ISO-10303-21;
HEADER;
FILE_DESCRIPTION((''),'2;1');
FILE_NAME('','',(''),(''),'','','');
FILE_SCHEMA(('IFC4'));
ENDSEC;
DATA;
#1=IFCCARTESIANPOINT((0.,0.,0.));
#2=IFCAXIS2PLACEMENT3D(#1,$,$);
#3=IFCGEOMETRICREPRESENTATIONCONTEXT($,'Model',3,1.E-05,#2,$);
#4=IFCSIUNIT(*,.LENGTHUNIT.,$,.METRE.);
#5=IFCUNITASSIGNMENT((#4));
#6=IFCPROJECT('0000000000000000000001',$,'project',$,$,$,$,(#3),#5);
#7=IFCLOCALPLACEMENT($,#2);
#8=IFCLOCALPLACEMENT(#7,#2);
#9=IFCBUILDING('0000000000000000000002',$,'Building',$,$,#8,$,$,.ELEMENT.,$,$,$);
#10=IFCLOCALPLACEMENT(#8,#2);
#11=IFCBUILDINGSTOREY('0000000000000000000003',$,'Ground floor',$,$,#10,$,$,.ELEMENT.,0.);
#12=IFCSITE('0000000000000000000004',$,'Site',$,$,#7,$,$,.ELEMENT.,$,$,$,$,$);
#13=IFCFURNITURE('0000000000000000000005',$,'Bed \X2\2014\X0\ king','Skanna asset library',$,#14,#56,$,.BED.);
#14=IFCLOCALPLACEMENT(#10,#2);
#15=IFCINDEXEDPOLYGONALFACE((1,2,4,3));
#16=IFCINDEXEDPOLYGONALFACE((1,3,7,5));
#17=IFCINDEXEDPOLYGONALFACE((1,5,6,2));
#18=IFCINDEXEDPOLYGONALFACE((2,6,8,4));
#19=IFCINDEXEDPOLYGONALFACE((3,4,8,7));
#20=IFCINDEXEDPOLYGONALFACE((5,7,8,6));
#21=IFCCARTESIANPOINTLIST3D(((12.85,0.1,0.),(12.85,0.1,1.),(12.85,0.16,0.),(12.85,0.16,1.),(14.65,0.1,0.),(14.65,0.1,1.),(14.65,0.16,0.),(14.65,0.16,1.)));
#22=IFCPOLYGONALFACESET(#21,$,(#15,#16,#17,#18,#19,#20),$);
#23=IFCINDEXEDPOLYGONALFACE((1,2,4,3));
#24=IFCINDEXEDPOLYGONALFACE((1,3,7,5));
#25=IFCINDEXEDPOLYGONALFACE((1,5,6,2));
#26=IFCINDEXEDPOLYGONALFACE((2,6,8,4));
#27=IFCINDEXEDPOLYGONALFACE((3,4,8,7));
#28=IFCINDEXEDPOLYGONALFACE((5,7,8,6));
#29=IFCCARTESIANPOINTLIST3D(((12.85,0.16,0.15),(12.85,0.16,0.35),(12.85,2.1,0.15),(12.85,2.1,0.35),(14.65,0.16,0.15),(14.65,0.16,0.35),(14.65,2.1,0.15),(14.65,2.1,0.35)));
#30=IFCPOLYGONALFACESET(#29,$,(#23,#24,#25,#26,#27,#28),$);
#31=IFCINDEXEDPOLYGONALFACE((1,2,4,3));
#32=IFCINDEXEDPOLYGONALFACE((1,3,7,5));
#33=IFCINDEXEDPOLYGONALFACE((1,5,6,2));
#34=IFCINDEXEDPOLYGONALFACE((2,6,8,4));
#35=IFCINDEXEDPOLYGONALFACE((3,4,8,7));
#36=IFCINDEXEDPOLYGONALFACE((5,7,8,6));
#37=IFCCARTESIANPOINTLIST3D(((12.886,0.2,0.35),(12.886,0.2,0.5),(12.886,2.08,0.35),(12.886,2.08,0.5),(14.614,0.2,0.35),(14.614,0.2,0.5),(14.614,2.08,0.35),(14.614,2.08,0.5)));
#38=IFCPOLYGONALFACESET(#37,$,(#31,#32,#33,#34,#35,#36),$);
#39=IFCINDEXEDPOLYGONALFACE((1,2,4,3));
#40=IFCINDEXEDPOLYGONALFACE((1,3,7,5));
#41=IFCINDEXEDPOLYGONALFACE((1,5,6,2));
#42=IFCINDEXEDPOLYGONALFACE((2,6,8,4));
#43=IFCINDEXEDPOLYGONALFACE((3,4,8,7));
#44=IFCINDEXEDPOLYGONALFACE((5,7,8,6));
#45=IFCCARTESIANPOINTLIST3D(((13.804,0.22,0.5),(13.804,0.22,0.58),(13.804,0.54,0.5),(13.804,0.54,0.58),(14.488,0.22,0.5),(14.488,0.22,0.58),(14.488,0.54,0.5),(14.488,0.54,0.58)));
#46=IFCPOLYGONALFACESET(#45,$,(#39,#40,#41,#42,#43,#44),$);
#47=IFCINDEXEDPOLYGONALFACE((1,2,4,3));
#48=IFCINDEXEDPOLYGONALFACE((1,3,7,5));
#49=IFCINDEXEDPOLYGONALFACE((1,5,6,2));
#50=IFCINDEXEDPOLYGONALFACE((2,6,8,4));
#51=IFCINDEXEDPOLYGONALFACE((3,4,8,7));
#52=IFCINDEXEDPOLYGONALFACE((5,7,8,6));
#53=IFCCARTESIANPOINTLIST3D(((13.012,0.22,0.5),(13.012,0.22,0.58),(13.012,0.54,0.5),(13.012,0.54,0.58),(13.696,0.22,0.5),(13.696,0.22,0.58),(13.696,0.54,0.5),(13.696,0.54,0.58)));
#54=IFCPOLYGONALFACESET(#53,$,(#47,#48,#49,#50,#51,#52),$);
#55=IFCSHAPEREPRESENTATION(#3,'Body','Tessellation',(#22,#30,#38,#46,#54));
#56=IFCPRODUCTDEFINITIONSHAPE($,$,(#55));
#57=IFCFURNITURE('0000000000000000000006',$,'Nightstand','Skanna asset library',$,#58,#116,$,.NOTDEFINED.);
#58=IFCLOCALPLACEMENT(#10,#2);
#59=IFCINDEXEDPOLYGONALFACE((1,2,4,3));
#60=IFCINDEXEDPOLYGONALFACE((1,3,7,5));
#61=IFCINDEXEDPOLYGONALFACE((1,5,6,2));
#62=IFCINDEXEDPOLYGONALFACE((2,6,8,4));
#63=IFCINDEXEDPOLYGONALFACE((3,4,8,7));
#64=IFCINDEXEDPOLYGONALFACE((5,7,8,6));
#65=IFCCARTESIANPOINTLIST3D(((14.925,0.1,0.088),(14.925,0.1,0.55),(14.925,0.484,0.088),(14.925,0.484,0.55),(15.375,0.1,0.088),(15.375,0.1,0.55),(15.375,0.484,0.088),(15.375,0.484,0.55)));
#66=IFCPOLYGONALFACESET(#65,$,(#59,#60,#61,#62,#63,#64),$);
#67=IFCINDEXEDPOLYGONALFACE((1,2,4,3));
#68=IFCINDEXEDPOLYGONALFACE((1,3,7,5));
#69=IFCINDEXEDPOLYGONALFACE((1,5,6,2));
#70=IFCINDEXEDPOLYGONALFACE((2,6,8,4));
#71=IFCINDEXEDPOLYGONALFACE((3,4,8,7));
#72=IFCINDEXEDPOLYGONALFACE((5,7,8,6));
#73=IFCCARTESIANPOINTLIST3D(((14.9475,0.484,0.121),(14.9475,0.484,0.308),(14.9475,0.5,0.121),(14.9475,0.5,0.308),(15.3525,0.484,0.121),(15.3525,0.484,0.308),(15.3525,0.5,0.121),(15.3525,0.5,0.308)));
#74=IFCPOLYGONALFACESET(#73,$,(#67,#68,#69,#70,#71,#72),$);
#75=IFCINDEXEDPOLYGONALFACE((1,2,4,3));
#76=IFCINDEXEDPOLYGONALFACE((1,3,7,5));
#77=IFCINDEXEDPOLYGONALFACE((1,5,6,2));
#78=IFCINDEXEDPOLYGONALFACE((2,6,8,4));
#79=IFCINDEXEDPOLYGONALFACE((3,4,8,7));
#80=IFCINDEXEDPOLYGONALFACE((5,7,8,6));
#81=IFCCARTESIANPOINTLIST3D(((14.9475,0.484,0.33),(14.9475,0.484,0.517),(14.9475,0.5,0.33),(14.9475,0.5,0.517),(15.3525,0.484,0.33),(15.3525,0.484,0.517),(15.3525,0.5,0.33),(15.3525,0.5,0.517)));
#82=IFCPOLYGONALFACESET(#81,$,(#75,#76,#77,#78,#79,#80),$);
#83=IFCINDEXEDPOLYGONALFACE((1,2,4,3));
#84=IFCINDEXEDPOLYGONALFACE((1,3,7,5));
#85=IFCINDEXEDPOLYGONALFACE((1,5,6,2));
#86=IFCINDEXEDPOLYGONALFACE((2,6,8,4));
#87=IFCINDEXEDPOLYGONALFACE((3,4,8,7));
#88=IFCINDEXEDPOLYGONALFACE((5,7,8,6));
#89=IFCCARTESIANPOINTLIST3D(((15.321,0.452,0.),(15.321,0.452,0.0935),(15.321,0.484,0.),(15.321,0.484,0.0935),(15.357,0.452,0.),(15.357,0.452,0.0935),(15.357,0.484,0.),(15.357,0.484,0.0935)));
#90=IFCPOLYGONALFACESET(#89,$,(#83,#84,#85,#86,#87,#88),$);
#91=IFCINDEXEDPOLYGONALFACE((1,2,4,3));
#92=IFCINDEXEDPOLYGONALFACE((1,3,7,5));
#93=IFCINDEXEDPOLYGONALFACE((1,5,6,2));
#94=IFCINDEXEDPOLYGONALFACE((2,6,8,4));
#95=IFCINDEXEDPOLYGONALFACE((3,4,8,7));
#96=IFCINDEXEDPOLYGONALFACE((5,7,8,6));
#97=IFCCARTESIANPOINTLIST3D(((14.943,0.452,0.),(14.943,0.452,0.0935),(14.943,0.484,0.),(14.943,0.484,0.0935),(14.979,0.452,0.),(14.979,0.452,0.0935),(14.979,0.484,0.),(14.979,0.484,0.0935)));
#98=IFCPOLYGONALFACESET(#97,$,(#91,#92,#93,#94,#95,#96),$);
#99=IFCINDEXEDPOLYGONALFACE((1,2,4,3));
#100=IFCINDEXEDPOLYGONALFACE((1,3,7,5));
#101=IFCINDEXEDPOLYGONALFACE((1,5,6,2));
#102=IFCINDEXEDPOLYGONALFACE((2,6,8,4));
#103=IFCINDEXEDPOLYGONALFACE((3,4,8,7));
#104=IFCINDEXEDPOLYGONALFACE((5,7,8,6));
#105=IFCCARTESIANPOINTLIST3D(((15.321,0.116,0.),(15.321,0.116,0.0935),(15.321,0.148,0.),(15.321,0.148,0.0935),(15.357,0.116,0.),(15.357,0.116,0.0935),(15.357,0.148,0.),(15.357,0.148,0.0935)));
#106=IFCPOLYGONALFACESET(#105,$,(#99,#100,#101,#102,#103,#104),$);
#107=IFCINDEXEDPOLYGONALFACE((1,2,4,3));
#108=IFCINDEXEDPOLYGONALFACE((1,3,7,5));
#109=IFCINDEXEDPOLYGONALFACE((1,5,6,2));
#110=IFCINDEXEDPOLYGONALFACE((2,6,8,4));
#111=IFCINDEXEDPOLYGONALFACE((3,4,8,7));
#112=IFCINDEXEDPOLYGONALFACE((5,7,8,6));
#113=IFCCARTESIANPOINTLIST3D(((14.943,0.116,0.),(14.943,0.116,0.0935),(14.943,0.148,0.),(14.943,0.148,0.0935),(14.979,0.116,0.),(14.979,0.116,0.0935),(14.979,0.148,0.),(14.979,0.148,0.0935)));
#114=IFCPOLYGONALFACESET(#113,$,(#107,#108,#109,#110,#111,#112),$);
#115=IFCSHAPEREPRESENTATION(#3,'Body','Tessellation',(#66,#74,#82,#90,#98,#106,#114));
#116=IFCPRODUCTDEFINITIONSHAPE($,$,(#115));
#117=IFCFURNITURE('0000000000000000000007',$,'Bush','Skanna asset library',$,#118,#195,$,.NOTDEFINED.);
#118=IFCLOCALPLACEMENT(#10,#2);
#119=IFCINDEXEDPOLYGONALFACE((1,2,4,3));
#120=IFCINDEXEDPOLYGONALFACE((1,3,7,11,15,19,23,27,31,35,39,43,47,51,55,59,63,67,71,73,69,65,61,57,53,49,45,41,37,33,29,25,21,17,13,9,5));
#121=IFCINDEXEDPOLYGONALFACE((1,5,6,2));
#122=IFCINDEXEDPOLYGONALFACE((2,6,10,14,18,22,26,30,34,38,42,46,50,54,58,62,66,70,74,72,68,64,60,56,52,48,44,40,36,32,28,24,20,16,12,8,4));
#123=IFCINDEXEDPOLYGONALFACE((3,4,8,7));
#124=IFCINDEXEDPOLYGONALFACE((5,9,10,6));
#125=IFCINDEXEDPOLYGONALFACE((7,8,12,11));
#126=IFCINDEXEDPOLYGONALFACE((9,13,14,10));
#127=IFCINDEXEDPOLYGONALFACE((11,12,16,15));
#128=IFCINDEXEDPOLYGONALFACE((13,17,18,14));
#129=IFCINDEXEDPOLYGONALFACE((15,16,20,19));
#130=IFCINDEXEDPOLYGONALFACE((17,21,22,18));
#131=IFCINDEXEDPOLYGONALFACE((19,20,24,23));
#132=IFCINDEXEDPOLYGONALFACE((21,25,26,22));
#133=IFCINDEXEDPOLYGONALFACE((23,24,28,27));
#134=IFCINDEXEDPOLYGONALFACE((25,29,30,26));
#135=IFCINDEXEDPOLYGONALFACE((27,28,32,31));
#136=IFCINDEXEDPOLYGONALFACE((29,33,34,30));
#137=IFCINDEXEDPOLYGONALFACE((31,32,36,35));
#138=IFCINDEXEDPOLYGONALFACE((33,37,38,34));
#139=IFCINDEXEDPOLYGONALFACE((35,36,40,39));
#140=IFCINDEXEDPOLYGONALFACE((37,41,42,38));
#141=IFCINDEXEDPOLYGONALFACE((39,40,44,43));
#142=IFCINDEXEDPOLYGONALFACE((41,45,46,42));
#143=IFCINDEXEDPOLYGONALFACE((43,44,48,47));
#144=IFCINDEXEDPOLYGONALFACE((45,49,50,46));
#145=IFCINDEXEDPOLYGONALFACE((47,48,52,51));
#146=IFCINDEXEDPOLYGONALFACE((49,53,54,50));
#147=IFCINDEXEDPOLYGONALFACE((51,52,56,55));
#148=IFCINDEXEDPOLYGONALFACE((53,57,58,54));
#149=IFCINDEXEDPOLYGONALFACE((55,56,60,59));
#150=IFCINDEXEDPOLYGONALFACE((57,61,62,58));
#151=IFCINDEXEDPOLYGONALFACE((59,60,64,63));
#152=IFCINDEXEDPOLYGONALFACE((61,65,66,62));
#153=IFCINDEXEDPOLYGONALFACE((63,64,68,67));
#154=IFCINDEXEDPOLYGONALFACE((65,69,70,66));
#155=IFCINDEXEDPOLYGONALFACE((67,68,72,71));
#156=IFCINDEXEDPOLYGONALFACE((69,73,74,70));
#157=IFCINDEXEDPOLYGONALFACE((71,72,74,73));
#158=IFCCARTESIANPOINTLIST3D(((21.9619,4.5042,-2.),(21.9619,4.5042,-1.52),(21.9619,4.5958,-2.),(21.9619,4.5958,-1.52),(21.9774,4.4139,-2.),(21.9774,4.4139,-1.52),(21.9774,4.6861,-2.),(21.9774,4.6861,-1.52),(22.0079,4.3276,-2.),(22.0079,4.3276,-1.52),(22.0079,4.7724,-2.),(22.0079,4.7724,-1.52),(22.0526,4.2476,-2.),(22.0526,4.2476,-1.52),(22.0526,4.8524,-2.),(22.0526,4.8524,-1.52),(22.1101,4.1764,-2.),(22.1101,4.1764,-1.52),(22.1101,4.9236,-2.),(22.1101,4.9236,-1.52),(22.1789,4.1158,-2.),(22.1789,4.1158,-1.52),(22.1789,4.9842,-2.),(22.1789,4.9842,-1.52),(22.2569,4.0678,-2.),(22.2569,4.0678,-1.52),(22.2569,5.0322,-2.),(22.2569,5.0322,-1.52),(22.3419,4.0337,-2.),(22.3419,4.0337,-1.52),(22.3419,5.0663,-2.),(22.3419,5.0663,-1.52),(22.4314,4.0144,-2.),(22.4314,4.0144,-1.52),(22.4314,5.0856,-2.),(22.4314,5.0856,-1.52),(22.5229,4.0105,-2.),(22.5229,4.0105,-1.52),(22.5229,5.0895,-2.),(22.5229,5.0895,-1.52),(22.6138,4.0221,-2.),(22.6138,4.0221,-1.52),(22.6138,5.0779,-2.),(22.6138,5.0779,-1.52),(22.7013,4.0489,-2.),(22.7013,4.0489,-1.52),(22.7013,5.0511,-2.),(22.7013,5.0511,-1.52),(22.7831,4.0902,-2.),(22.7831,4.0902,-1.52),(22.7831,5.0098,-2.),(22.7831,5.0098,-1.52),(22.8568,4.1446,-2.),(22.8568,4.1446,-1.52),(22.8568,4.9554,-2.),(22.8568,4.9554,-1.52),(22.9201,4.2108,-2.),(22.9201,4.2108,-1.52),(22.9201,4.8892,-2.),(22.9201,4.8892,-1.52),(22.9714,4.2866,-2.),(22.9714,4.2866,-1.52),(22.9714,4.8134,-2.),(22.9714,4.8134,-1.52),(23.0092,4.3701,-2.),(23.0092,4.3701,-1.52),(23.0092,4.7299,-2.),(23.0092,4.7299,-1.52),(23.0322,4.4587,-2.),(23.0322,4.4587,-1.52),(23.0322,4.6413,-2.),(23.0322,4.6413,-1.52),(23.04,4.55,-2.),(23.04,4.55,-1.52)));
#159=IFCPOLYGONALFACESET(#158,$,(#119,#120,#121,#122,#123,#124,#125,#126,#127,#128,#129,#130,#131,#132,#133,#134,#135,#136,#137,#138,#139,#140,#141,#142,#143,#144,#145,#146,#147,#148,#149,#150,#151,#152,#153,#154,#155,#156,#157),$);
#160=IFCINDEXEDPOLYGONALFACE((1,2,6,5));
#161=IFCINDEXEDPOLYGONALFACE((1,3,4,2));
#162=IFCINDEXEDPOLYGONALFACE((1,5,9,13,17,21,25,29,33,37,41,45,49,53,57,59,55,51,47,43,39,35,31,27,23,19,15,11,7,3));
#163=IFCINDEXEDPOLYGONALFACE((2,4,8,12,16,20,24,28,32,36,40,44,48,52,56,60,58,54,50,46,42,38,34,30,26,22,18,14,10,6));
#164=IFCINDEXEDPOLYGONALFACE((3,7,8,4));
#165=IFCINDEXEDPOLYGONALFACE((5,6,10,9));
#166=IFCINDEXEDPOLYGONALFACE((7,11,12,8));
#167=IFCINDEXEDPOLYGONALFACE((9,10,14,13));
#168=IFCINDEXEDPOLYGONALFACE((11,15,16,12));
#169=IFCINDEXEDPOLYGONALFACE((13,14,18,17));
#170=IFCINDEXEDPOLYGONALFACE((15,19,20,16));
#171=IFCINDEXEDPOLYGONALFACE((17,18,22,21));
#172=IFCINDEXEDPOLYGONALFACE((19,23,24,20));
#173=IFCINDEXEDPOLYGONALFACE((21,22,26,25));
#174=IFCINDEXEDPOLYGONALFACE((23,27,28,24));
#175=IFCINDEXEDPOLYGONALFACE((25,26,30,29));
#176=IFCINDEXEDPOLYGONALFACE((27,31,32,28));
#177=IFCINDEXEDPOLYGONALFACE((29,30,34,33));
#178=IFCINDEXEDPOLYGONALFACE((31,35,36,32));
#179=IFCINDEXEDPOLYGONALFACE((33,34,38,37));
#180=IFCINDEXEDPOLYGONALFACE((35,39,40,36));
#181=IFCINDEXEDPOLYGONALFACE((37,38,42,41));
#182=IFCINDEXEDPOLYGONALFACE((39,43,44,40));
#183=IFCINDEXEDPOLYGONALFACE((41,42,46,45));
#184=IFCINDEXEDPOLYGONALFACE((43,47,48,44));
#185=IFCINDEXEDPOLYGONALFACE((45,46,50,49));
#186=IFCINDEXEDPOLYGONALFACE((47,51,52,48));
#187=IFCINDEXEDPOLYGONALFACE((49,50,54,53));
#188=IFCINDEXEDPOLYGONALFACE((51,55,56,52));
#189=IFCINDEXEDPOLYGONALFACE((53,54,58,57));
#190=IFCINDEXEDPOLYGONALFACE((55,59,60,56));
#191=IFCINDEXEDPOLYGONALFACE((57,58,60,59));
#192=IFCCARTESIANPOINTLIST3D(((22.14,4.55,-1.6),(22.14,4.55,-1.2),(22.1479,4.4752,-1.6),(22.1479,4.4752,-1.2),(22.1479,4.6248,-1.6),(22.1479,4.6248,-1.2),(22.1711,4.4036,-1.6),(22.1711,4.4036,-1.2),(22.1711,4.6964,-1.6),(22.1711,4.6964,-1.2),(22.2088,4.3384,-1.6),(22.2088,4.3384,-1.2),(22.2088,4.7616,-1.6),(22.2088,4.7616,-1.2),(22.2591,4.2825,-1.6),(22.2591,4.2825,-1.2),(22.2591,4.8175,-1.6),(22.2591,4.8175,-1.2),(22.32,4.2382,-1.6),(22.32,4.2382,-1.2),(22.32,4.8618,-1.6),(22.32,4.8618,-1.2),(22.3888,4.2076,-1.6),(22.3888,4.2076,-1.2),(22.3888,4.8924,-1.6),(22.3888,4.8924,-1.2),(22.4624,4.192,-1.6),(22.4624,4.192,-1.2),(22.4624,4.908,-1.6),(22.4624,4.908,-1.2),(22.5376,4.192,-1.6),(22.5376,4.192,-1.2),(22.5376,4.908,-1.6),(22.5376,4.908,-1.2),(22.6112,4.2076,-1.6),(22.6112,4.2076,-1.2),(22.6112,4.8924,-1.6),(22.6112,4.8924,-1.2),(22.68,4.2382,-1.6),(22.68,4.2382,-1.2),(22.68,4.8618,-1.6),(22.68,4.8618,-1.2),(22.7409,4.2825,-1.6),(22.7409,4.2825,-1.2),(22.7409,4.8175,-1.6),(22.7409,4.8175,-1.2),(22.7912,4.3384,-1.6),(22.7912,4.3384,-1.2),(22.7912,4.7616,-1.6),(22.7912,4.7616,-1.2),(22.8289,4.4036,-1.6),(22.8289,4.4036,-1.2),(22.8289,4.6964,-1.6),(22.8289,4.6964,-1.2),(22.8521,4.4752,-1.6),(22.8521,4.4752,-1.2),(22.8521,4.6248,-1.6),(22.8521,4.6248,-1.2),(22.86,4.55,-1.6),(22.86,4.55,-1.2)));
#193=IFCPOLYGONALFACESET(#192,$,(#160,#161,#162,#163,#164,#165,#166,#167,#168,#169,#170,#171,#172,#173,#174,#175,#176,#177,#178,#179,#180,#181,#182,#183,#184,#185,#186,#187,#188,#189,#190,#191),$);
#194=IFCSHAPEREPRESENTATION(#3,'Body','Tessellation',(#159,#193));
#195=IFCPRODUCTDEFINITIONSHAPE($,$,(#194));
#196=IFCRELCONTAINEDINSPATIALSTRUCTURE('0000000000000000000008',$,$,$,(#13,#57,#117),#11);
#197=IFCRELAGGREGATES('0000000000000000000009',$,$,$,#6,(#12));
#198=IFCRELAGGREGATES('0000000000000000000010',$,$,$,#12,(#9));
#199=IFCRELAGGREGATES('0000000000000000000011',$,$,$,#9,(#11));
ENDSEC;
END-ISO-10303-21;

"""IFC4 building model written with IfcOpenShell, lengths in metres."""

from ifc_helpers import new_model, si_unit, frame, frame_2d, origin, origin_2d, place, context, project, spatial, rectangle, circle, extrude, element, save


model = new_model("IFC4")

# Units and contexts
model_context = context("Model", 3, precision=1e-05, world=origin())
ifc_project = project(units=[si_unit("LENGTHUNIT", "METRE")], contexts=[model_context])

# Site, building, storey
site_placement = place(None, origin())
site = spatial("IfcSite", under=ifc_project, at=site_placement, Name="Site", CompositionType="ELEMENT")
building_placement = place(site_placement, origin())
building = spatial("IfcBuilding", under=site, at=building_placement, Name="Building", CompositionType="ELEMENT")
storey_placement = place(building_placement, origin())
storey = spatial("IfcBuildingStorey", under=building, at=storey_placement, Name="Ground floor", CompositionType="ELEMENT", Elevation=0.0)

# Furniture
furniture_1_placement = place(storey_placement, frame((13.75, 1.1, 0.0), z_axis=(0.0, 0.0, 1.0), x_axis=(-1.0, 0.0, 0.0)))
element("IfcFurniture", 1, at=furniture_1_placement, inside=storey, Name="Bed — king", Description="Skanna asset library", PredefinedType="BED", context=model_context, shape_type="SweptSolid", body=[
    extrude(rectangle(XDim=1.8, YDim=0.06, at=frame_2d((0.0, 0.97))), origin(), (0.0, 0.0, 1.0), 1.0),
    extrude(rectangle(XDim=1.8, YDim=1.94, at=frame_2d((0.0, -0.03))), frame((0.0, 0.0, 0.15)), (0.0, 0.0, 1.0), 0.2),
    extrude(rectangle(XDim=1.728, YDim=1.88, at=frame_2d((0.0, -0.04))), frame((0.0, 0.0, 0.35)), (0.0, 0.0, 1.0), 0.15),
    extrude(rectangle(XDim=0.684, YDim=0.32, at=frame_2d((-0.396, 0.72))), frame((0.0, 0.0, 0.5)), (0.0, 0.0, 1.0), 0.08),
    extrude(rectangle(XDim=0.684, YDim=0.32, at=frame_2d((0.396, 0.72))), frame((0.0, 0.0, 0.5)), (0.0, 0.0, 1.0), 0.08),
])
furniture_2_placement = place(storey_placement, frame((15.15, 0.3, 0.0), z_axis=(0.0, 0.0, 1.0), x_axis=(-1.0, 0.0, 0.0)))
element("IfcFurniture", 2, at=furniture_2_placement, inside=storey, Name="Nightstand", Description="Skanna asset library", PredefinedType="NOTDEFINED", context=model_context, shape_type="SweptSolid", body=[
    extrude(rectangle(XDim=0.45, YDim=0.384, at=frame_2d((0.0, 0.008))), frame((0.0, 0.0, 0.088)), (0.0, 0.0, 1.0), 0.462),
    extrude(rectangle(XDim=0.405, YDim=0.016, at=frame_2d((0.0, -0.192))), frame((0.0, 0.0, 0.121)), (0.0, 0.0, 1.0), 0.187),
    extrude(rectangle(XDim=0.405, YDim=0.016, at=frame_2d((0.0, -0.192))), frame((0.0, 0.0, 0.33)), (0.0, 0.0, 1.0), 0.187),
    extrude(rectangle(XDim=0.036, YDim=0.032, at=frame_2d((-0.189, -0.168))), origin(), (0.0, 0.0, 1.0), 0.0935),
    extrude(rectangle(XDim=0.036, YDim=0.032, at=frame_2d((0.189, -0.168))), origin(), (0.0, 0.0, 1.0), 0.0935),
    extrude(rectangle(XDim=0.036, YDim=0.032, at=frame_2d((-0.189, 0.168))), origin(), (0.0, 0.0, 1.0), 0.0935),
    extrude(rectangle(XDim=0.036, YDim=0.032, at=frame_2d((0.189, 0.168))), origin(), (0.0, 0.0, 1.0), 0.0935),
])
for number, where, z_axis, x_axis, name in (
    (3, (22.5, 4.55, -2.0), (0.0, 0.0, 1.0), (1.0, 0.0, 0.0), "Bush"),
):
    element("IfcFurniture", number, at=place(storey_placement, frame(where, z_axis=z_axis, x_axis=x_axis)), inside=storey, Name=name, Description="Skanna asset library", PredefinedType="NOTDEFINED", context=model_context, shape_type="SweptSolid", body=[
        extrude(circle(Radius=0.54, at=origin_2d()), origin(), (0.0, 0.0, 1.0), 0.48),
        extrude(circle(Radius=0.36, at=origin_2d()), frame((0.0, 0.0, 0.4)), (0.0, 0.0, 1.0), 0.4),
    ])

save(model, "model.ifc")
